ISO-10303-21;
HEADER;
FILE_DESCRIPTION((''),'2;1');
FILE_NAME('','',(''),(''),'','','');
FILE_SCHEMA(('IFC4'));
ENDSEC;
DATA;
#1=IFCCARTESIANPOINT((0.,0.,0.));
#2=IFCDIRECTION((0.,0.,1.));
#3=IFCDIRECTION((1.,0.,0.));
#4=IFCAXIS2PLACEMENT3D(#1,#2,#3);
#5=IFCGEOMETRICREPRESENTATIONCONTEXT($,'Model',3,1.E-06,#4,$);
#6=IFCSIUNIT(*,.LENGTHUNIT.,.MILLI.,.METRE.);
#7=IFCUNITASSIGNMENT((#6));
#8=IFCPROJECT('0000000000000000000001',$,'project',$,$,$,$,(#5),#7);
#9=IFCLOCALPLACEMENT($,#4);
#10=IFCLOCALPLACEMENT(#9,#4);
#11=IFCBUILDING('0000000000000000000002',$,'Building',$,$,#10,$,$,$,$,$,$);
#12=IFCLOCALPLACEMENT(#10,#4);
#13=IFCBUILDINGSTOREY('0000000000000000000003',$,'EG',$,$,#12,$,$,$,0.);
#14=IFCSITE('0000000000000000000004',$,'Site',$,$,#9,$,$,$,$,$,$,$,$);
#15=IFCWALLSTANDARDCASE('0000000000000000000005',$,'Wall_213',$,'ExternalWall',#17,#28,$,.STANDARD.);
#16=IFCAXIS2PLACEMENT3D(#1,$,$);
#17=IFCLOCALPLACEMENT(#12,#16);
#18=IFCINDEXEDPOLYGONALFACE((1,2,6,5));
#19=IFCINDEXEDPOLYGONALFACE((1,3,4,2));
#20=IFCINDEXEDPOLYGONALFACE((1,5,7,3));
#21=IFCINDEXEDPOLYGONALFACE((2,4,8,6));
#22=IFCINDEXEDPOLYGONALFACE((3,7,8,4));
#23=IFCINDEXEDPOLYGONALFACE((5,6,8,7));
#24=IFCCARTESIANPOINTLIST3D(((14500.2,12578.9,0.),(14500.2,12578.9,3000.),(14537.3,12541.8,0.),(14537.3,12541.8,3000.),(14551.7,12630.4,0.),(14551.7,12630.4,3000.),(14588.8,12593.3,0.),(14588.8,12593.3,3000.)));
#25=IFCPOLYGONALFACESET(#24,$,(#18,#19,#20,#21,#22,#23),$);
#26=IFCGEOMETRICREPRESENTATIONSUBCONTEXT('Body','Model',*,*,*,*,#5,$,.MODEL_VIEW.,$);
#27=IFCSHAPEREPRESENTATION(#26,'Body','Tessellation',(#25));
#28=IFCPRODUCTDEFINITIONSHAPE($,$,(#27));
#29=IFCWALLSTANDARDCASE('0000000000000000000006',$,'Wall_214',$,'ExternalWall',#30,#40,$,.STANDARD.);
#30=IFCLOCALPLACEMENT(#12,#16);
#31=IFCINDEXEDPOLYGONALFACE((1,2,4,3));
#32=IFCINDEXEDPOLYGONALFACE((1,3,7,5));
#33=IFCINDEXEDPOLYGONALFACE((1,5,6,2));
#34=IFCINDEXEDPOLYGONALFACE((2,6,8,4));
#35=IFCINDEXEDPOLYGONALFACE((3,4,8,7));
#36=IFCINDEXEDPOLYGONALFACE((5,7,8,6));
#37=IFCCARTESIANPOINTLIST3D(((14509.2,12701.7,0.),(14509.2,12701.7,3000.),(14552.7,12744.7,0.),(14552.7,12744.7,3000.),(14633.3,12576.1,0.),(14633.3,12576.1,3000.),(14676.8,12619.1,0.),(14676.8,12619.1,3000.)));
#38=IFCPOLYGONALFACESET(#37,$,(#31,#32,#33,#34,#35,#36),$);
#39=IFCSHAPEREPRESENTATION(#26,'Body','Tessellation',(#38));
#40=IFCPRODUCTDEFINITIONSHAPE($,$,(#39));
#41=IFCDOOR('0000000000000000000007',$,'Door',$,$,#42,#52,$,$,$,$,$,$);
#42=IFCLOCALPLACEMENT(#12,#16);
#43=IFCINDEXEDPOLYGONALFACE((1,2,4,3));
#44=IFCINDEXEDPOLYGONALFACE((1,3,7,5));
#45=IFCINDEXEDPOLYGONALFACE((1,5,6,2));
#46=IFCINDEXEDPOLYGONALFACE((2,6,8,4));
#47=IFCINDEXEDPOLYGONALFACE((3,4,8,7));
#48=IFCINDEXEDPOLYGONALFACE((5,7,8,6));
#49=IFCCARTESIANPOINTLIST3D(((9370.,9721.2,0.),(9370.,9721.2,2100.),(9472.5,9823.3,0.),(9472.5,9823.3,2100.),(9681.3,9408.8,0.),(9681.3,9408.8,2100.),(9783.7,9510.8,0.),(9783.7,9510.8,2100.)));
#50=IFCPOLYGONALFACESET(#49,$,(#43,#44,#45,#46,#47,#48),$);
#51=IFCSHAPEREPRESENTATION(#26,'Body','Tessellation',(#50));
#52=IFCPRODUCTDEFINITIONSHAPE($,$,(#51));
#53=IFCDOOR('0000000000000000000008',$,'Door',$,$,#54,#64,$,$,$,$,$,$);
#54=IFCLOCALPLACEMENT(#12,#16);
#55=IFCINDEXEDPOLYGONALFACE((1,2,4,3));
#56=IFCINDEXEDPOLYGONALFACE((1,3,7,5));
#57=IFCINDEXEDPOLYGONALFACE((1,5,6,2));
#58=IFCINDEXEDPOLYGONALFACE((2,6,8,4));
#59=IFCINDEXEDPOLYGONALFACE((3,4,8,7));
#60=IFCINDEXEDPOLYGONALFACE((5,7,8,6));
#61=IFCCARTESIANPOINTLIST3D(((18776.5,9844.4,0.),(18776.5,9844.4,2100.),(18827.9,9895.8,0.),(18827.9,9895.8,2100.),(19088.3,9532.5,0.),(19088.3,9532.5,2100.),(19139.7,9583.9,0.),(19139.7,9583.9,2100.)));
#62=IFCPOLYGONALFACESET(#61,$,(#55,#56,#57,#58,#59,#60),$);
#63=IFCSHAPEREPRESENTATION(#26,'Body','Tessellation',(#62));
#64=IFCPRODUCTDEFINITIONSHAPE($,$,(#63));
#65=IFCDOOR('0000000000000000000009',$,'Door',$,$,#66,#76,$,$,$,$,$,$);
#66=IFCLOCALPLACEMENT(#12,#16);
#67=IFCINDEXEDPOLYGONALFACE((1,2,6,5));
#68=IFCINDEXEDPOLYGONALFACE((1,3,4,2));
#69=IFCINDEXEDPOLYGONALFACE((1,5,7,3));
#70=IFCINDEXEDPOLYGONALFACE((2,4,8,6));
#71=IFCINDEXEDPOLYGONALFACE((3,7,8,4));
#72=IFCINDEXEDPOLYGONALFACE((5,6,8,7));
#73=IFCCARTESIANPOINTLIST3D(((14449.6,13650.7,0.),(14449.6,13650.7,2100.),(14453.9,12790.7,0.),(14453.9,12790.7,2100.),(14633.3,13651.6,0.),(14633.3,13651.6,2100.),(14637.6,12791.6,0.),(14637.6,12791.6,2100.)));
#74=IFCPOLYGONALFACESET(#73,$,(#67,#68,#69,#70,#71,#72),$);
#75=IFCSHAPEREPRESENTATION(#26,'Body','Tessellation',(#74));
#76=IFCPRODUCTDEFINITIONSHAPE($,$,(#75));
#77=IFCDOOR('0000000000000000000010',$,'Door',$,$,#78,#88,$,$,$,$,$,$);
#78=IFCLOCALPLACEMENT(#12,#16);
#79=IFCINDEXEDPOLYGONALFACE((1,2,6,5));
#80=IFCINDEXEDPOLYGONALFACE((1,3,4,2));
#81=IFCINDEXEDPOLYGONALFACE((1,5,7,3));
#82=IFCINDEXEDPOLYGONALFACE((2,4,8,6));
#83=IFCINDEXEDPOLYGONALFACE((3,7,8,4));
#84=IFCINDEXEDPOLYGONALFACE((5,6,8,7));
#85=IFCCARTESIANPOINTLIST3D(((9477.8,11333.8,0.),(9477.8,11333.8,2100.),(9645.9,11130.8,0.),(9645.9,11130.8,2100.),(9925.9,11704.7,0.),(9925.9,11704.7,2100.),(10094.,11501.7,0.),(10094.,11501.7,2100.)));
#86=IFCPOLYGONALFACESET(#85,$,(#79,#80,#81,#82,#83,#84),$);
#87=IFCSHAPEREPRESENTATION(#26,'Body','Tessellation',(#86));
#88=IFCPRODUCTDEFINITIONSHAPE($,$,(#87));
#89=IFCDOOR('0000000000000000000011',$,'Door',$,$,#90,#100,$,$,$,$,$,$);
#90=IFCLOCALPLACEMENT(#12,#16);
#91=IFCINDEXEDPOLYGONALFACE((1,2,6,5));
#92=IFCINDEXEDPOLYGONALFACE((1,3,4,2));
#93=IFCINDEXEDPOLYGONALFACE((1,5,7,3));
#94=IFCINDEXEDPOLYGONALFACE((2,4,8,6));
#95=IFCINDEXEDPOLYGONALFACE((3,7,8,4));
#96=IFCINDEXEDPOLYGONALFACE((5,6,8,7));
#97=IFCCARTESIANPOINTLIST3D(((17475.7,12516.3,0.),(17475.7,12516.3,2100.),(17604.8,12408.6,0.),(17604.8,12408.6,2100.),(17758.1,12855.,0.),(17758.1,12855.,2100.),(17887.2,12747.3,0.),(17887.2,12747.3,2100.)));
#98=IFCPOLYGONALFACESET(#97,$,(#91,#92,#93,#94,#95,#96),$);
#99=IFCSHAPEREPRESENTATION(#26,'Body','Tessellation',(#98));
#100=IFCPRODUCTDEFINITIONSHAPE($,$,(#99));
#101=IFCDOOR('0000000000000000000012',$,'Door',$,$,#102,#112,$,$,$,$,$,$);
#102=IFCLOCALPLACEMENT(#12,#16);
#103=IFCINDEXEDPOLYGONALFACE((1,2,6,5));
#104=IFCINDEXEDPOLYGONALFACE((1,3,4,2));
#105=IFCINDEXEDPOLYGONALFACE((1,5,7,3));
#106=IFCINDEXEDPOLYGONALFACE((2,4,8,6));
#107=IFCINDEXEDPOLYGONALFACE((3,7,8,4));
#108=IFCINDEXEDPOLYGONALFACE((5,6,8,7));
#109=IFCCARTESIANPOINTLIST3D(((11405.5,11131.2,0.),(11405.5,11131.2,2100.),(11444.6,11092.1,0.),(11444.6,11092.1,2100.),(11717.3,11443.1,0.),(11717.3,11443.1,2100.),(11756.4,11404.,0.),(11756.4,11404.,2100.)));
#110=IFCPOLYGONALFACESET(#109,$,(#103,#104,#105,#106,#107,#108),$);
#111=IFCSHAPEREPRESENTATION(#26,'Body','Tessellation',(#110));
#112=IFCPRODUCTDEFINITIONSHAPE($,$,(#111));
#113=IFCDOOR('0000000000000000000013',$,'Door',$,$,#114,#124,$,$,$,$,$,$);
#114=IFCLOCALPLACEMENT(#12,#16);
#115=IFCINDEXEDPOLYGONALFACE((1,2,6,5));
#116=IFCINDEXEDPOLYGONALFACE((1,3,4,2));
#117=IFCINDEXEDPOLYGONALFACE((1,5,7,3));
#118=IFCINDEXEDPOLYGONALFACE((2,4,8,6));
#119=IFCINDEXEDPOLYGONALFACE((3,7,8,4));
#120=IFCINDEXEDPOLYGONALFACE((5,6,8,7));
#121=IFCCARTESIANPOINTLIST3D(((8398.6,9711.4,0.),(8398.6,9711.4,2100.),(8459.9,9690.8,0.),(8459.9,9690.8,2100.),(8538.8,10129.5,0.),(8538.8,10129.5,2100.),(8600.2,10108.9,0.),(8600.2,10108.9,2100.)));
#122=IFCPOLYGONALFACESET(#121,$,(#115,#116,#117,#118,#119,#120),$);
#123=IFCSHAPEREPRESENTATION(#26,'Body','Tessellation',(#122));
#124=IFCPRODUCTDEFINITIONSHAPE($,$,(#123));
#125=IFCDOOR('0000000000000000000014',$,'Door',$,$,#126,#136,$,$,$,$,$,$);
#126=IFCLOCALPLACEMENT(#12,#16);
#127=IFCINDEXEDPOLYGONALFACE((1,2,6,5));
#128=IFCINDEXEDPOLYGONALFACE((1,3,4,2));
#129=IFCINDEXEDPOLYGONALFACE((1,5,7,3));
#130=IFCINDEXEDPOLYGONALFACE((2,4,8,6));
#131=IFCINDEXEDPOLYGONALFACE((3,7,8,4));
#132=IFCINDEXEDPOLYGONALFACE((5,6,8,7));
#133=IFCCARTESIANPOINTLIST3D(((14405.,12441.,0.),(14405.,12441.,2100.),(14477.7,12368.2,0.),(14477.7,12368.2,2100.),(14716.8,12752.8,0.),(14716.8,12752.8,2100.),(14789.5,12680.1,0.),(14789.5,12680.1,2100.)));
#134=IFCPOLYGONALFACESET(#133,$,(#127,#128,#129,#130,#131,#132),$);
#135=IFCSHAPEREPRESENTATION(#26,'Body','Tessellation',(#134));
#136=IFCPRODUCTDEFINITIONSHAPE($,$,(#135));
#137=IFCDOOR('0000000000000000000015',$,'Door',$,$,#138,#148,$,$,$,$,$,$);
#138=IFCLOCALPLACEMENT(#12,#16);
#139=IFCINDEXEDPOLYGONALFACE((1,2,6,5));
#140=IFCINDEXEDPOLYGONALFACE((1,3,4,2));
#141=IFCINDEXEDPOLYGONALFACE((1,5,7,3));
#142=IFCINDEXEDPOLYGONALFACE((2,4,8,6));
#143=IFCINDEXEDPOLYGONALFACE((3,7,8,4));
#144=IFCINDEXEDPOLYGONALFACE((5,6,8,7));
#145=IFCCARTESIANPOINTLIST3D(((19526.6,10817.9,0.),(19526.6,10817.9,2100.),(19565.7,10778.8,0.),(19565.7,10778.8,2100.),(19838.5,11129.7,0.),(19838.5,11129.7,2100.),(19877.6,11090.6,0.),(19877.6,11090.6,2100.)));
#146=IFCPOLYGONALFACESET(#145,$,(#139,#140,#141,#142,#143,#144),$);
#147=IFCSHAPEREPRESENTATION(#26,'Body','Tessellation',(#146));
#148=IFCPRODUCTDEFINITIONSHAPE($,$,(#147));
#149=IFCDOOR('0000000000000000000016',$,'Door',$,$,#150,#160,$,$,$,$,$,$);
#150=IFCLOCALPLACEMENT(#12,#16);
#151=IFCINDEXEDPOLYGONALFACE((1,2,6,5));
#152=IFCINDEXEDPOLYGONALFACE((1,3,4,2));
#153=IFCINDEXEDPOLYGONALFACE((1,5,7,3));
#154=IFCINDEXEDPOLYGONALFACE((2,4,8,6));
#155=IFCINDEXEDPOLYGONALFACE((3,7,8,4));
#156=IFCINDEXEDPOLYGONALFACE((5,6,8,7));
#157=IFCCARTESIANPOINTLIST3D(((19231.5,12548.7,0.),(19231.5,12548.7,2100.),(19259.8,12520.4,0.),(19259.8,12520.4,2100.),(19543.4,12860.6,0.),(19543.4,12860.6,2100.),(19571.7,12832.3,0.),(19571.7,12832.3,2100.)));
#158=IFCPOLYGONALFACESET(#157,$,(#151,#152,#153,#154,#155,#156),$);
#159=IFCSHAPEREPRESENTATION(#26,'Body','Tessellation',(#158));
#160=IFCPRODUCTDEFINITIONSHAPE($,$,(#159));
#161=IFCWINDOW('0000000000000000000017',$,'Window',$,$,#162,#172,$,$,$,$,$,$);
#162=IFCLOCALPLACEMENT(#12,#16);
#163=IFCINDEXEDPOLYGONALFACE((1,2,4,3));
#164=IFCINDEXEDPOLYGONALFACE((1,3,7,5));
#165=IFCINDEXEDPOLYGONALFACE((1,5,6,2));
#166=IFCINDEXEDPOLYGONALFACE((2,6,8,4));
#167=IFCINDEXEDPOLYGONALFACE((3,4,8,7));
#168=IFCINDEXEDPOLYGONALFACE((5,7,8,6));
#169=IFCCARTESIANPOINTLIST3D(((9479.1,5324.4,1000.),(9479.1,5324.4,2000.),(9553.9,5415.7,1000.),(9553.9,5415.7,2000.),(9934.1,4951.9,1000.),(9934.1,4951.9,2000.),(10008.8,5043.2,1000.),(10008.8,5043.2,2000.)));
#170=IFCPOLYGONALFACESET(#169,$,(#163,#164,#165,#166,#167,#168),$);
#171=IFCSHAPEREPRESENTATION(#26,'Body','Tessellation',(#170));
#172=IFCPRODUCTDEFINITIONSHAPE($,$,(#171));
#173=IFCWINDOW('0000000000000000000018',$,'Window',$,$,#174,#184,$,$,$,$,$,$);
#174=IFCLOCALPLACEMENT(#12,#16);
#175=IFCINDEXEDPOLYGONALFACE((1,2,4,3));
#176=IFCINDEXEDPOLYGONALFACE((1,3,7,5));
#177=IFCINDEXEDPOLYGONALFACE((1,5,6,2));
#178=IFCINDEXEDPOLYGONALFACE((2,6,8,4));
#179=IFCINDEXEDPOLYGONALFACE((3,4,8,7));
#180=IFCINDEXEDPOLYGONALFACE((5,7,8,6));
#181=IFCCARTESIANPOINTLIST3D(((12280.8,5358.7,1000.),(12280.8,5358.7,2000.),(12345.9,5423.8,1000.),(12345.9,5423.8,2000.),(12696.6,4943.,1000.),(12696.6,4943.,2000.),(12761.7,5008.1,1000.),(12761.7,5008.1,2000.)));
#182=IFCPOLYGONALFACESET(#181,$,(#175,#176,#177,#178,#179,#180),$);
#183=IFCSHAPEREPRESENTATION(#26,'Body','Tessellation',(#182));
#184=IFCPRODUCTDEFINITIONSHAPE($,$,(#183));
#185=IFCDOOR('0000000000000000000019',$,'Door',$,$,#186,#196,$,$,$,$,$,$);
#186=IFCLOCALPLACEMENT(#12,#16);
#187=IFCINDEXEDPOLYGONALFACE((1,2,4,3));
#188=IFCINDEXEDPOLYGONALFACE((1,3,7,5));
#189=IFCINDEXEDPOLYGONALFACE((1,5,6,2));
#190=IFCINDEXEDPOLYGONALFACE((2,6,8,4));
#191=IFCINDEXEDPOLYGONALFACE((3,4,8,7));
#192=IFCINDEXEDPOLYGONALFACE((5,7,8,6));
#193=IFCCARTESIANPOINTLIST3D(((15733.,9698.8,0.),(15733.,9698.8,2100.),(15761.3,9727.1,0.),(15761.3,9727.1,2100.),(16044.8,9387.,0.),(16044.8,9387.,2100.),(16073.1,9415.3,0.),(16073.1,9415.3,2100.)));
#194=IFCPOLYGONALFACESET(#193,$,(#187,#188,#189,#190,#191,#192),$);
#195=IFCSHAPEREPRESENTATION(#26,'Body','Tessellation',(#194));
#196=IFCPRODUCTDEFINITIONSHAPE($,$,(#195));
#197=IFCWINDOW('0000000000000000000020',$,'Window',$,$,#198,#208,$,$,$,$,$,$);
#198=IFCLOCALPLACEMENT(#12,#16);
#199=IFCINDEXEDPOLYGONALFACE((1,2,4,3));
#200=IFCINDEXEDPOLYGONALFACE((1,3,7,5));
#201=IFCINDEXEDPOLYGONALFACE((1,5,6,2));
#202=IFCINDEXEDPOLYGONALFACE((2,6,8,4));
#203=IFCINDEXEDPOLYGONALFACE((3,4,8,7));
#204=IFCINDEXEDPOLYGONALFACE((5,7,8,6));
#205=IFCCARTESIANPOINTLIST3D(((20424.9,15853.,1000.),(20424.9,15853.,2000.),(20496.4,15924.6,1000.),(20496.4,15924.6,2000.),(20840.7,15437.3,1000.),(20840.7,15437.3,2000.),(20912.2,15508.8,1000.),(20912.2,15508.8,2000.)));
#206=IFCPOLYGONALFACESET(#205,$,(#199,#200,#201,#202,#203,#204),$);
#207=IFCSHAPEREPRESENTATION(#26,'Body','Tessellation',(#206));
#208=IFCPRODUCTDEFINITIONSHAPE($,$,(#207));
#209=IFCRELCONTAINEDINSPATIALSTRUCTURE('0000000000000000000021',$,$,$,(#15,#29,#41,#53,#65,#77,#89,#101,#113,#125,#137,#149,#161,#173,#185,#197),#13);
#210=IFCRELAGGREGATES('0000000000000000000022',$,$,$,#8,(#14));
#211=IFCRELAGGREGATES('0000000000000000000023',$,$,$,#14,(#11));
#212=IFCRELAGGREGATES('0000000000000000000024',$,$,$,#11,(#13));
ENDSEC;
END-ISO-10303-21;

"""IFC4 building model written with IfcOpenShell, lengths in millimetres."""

from ifc_helpers import new_model, si_unit, frame, origin_with_axes, place, context, subcontext, project, spatial, rectangle, extrude, element, save


model = new_model("IFC4")

# Units and contexts
model_context = context("Model", 3, precision=1e-06, world=origin_with_axes())
body_context = subcontext(model_context, "Body", "Model", "MODEL_VIEW")
ifc_project = project(units=[si_unit("LENGTHUNIT", "METRE", prefix="MILLI")], contexts=[model_context])

# Site, building, storey
site_placement = place(None, origin_with_axes())
site = spatial("IfcSite", under=ifc_project, at=site_placement, Name="Site")
building_placement = place(site_placement, origin_with_axes())
building = spatial("IfcBuilding", under=site, at=building_placement, Name="Building")
storey_placement = place(building_placement, origin_with_axes())
storey = spatial("IfcBuildingStorey", under=building, at=storey_placement, Name="EG", Elevation=0.0)

# Walls
wall_1_placement = place(storey_placement, origin_with_axes())
element("IfcWallStandardCase", 1, at=wall_1_placement, inside=storey, Name="Wall_213", ObjectType="ExternalWall", PredefinedType="STANDARD", context=body_context, shape_type="SweptSolid", body=[
    extrude(rectangle(XDim=72.8, YDim=52.5), frame((14544.5, 12586.1, 0.0), z_axis=(0.0, 0.0, 1.0), x_axis=(-0.707107, -0.707107, 0.0)), (0.0, 0.0, 1.0), 3000.0),
])
wall_2_placement = place(storey_placement, origin_with_axes())
element("IfcWallStandardCase", 2, at=wall_2_placement, inside=storey, Name="Wall_214", ObjectType="ExternalWall", PredefinedType="STANDARD", context=body_context, shape_type="SweptSolid", body=[
    extrude(rectangle(XDim=61.2, YDim=176.6), frame((14593.0, 12660.4, 0.0), z_axis=(0.0, 0.0, 1.0), x_axis=(-0.711182, -0.703008, 0.0)), (0.0, 0.0, 1.0), 3000.0),
])

# Doors
door_1_placement = place(storey_placement, origin_with_axes())
element("IfcDoor", 3, at=door_1_placement, inside=storey, Name="Door", context=body_context, shape_type="SweptSolid", body=[
    extrude(rectangle(XDim=441.0, YDim=144.6), frame((9576.9, 9616.0, 0.0), z_axis=(0.0, 0.0, 1.0), x_axis=(0.705748, -0.708463, 0.0)), (0.0, 0.0, 1.0), 2100.0),
])
door_2_placement = place(storey_placement, origin_with_axes())
element("IfcDoor", 4, at=door_2_placement, inside=storey, Name="Door", context=body_context, shape_type="SweptSolid", body=[
    extrude(rectangle(XDim=441.0, YDim=72.7), frame((18958.1, 9714.2, 0.0), z_axis=(0.0, 0.0, 1.0), x_axis=(0.707107, -0.707107, 0.0)), (0.0, 0.0, 1.0), 2100.0),
])
door_3_placement = place(storey_placement, origin_with_axes())
element("IfcDoor", 5, at=door_3_placement, inside=storey, Name="Door", context=body_context, shape_type="SweptSolid", body=[
    extrude(rectangle(XDim=860.0, YDim=183.7), frame((14543.6, 13221.2, 0.0), z_axis=(0.0, 0.0, 1.0), x_axis=(0.004952, -0.999988, 0.0)), (0.0, 0.0, 1.0), 2100.0),
])
door_4_placement = place(storey_placement, origin_with_axes())
element("IfcDoor", 6, at=door_4_placement, inside=storey, Name="Door", context=body_context, shape_type="SweptSolid", body=[
    extrude(rectangle(XDim=581.7, YDim=263.6), frame((9785.9, 11417.7, 0.0), z_axis=(0.0, 0.0, 1.0), x_axis=(-0.770323, -0.637654, 0.0)), (0.0, 0.0, 1.0), 2100.0),
])
door_5_placement = place(storey_placement, origin_with_axes())
element("IfcDoor", 7, at=door_5_placement, inside=storey, Name="Door", context=body_context, shape_type="SweptSolid", body=[
    extrude(rectangle(XDim=441.0, YDim=168.2), frame((17681.4, 12631.8, 0.0), z_axis=(0.0, 0.0, 1.0), x_axis=(-0.640378, -0.76806, 0.0)), (0.0, 0.0, 1.0), 2100.0),
])
door_6_placement = place(storey_placement, origin_with_axes())
element("IfcDoor", 8, at=door_6_placement, inside=storey, Name="Door", context=body_context, shape_type="SweptSolid", body=[
    extrude(rectangle(XDim=441.0, YDim=55.3), frame((11581.0, 11267.6, 0.0), z_axis=(0.0, 0.0, 1.0), x_axis=(-0.707107, -0.707107, 0.0)), (0.0, 0.0, 1.0), 2100.0),
])
door_7_placement = place(storey_placement, origin_with_axes())
element("IfcDoor", 9, at=door_7_placement, inside=storey, Name="Door", context=body_context, shape_type="SweptSolid", body=[
    extrude(rectangle(XDim=441.0, YDim=64.7), frame((8499.4, 9910.1, 0.0), z_axis=(0.0, 0.0, 1.0), x_axis=(0.318062, 0.94807, 0.0)), (0.0, 0.0, 1.0), 2100.0),
])
door_8_placement = place(storey_placement, origin_with_axes())
element("IfcDoor", 10, at=door_8_placement, inside=storey, Name="Door", context=body_context, shape_type="SweptSolid", body=[
    extrude(rectangle(XDim=441.0, YDim=102.9), frame((14597.3, 12560.5, 0.0), z_axis=(0.0, 0.0, 1.0), x_axis=(-0.707107, -0.707107, 0.0)), (0.0, 0.0, 1.0), 2100.0),
])
door_9_placement = place(storey_placement, origin_with_axes())
element("IfcDoor", 11, at=door_9_placement, inside=storey, Name="Door", context=body_context, shape_type="SweptSolid", body=[
    extrude(rectangle(XDim=441.0, YDim=55.3), frame((19702.1, 10954.2, 0.0), z_axis=(0.0, 0.0, 1.0), x_axis=(-0.707107, -0.707107, 0.0)), (0.0, 0.0, 1.0), 2100.0),
])
door_10_placement = place(storey_placement, origin_with_axes())
element("IfcDoor", 12, at=door_10_placement, inside=storey, Name="Door", context=body_context, shape_type="SweptSolid", body=[
    extrude(rectangle(XDim=441.0, YDim=40.0), frame((19401.6, 12690.5, 0.0), z_axis=(0.0, 0.0, 1.0), x_axis=(-0.707107, -0.707107, 0.0)), (0.0, 0.0, 1.0), 2100.0),
])

# Windows
window_1_placement = place(storey_placement, origin_with_axes())
element("IfcWindow", 13, at=window_1_placement, inside=storey, Name="Window", context=body_context, shape_type="SweptSolid", body=[
    extrude(rectangle(XDim=588.0, YDim=118.0), frame((9744.0, 5183.8, 1000.0), z_axis=(0.0, 0.0, 1.0), x_axis=(0.773717, -0.633531, 0.0)), (0.0, 0.0, 1.0), 1000.0),
])
window_2_placement = place(storey_placement, origin_with_axes())
element("IfcWindow", 14, at=window_2_placement, inside=storey, Name="Window", context=body_context, shape_type="SweptSolid", body=[
    extrude(rectangle(XDim=588.0, YDim=92.0), frame((12521.2, 5183.4, 1000.0), z_axis=(0.0, 0.0, 1.0), x_axis=(0.707107, -0.707107, 0.0)), (0.0, 0.0, 1.0), 1000.0),
])

# Door
door_11_placement = place(storey_placement, origin_with_axes())
element("IfcDoor", 15, at=door_11_placement, inside=storey, Name="Door", context=body_context, shape_type="SweptSolid", body=[
    extrude(rectangle(XDim=441.0, YDim=40.0), frame((15903.0, 9557.0, 0.0), z_axis=(0.0, 0.0, 1.0), x_axis=(0.707107, -0.707107, 0.0)), (0.0, 0.0, 1.0), 2100.0),
])

# Window
window_3_placement = place(storey_placement, origin_with_axes())
element("IfcWindow", 16, at=window_3_placement, inside=storey, Name="Window", context=body_context, shape_type="SweptSolid", body=[
    extrude(rectangle(XDim=588.0, YDim=101.2), frame((20668.6, 15680.9, 1000.0), z_axis=(0.0, 0.0, 1.0), x_axis=(0.707107, -0.707107, 0.0)), (0.0, 0.0, 1.0), 1000.0),
])

save(model, "model.ifc")
